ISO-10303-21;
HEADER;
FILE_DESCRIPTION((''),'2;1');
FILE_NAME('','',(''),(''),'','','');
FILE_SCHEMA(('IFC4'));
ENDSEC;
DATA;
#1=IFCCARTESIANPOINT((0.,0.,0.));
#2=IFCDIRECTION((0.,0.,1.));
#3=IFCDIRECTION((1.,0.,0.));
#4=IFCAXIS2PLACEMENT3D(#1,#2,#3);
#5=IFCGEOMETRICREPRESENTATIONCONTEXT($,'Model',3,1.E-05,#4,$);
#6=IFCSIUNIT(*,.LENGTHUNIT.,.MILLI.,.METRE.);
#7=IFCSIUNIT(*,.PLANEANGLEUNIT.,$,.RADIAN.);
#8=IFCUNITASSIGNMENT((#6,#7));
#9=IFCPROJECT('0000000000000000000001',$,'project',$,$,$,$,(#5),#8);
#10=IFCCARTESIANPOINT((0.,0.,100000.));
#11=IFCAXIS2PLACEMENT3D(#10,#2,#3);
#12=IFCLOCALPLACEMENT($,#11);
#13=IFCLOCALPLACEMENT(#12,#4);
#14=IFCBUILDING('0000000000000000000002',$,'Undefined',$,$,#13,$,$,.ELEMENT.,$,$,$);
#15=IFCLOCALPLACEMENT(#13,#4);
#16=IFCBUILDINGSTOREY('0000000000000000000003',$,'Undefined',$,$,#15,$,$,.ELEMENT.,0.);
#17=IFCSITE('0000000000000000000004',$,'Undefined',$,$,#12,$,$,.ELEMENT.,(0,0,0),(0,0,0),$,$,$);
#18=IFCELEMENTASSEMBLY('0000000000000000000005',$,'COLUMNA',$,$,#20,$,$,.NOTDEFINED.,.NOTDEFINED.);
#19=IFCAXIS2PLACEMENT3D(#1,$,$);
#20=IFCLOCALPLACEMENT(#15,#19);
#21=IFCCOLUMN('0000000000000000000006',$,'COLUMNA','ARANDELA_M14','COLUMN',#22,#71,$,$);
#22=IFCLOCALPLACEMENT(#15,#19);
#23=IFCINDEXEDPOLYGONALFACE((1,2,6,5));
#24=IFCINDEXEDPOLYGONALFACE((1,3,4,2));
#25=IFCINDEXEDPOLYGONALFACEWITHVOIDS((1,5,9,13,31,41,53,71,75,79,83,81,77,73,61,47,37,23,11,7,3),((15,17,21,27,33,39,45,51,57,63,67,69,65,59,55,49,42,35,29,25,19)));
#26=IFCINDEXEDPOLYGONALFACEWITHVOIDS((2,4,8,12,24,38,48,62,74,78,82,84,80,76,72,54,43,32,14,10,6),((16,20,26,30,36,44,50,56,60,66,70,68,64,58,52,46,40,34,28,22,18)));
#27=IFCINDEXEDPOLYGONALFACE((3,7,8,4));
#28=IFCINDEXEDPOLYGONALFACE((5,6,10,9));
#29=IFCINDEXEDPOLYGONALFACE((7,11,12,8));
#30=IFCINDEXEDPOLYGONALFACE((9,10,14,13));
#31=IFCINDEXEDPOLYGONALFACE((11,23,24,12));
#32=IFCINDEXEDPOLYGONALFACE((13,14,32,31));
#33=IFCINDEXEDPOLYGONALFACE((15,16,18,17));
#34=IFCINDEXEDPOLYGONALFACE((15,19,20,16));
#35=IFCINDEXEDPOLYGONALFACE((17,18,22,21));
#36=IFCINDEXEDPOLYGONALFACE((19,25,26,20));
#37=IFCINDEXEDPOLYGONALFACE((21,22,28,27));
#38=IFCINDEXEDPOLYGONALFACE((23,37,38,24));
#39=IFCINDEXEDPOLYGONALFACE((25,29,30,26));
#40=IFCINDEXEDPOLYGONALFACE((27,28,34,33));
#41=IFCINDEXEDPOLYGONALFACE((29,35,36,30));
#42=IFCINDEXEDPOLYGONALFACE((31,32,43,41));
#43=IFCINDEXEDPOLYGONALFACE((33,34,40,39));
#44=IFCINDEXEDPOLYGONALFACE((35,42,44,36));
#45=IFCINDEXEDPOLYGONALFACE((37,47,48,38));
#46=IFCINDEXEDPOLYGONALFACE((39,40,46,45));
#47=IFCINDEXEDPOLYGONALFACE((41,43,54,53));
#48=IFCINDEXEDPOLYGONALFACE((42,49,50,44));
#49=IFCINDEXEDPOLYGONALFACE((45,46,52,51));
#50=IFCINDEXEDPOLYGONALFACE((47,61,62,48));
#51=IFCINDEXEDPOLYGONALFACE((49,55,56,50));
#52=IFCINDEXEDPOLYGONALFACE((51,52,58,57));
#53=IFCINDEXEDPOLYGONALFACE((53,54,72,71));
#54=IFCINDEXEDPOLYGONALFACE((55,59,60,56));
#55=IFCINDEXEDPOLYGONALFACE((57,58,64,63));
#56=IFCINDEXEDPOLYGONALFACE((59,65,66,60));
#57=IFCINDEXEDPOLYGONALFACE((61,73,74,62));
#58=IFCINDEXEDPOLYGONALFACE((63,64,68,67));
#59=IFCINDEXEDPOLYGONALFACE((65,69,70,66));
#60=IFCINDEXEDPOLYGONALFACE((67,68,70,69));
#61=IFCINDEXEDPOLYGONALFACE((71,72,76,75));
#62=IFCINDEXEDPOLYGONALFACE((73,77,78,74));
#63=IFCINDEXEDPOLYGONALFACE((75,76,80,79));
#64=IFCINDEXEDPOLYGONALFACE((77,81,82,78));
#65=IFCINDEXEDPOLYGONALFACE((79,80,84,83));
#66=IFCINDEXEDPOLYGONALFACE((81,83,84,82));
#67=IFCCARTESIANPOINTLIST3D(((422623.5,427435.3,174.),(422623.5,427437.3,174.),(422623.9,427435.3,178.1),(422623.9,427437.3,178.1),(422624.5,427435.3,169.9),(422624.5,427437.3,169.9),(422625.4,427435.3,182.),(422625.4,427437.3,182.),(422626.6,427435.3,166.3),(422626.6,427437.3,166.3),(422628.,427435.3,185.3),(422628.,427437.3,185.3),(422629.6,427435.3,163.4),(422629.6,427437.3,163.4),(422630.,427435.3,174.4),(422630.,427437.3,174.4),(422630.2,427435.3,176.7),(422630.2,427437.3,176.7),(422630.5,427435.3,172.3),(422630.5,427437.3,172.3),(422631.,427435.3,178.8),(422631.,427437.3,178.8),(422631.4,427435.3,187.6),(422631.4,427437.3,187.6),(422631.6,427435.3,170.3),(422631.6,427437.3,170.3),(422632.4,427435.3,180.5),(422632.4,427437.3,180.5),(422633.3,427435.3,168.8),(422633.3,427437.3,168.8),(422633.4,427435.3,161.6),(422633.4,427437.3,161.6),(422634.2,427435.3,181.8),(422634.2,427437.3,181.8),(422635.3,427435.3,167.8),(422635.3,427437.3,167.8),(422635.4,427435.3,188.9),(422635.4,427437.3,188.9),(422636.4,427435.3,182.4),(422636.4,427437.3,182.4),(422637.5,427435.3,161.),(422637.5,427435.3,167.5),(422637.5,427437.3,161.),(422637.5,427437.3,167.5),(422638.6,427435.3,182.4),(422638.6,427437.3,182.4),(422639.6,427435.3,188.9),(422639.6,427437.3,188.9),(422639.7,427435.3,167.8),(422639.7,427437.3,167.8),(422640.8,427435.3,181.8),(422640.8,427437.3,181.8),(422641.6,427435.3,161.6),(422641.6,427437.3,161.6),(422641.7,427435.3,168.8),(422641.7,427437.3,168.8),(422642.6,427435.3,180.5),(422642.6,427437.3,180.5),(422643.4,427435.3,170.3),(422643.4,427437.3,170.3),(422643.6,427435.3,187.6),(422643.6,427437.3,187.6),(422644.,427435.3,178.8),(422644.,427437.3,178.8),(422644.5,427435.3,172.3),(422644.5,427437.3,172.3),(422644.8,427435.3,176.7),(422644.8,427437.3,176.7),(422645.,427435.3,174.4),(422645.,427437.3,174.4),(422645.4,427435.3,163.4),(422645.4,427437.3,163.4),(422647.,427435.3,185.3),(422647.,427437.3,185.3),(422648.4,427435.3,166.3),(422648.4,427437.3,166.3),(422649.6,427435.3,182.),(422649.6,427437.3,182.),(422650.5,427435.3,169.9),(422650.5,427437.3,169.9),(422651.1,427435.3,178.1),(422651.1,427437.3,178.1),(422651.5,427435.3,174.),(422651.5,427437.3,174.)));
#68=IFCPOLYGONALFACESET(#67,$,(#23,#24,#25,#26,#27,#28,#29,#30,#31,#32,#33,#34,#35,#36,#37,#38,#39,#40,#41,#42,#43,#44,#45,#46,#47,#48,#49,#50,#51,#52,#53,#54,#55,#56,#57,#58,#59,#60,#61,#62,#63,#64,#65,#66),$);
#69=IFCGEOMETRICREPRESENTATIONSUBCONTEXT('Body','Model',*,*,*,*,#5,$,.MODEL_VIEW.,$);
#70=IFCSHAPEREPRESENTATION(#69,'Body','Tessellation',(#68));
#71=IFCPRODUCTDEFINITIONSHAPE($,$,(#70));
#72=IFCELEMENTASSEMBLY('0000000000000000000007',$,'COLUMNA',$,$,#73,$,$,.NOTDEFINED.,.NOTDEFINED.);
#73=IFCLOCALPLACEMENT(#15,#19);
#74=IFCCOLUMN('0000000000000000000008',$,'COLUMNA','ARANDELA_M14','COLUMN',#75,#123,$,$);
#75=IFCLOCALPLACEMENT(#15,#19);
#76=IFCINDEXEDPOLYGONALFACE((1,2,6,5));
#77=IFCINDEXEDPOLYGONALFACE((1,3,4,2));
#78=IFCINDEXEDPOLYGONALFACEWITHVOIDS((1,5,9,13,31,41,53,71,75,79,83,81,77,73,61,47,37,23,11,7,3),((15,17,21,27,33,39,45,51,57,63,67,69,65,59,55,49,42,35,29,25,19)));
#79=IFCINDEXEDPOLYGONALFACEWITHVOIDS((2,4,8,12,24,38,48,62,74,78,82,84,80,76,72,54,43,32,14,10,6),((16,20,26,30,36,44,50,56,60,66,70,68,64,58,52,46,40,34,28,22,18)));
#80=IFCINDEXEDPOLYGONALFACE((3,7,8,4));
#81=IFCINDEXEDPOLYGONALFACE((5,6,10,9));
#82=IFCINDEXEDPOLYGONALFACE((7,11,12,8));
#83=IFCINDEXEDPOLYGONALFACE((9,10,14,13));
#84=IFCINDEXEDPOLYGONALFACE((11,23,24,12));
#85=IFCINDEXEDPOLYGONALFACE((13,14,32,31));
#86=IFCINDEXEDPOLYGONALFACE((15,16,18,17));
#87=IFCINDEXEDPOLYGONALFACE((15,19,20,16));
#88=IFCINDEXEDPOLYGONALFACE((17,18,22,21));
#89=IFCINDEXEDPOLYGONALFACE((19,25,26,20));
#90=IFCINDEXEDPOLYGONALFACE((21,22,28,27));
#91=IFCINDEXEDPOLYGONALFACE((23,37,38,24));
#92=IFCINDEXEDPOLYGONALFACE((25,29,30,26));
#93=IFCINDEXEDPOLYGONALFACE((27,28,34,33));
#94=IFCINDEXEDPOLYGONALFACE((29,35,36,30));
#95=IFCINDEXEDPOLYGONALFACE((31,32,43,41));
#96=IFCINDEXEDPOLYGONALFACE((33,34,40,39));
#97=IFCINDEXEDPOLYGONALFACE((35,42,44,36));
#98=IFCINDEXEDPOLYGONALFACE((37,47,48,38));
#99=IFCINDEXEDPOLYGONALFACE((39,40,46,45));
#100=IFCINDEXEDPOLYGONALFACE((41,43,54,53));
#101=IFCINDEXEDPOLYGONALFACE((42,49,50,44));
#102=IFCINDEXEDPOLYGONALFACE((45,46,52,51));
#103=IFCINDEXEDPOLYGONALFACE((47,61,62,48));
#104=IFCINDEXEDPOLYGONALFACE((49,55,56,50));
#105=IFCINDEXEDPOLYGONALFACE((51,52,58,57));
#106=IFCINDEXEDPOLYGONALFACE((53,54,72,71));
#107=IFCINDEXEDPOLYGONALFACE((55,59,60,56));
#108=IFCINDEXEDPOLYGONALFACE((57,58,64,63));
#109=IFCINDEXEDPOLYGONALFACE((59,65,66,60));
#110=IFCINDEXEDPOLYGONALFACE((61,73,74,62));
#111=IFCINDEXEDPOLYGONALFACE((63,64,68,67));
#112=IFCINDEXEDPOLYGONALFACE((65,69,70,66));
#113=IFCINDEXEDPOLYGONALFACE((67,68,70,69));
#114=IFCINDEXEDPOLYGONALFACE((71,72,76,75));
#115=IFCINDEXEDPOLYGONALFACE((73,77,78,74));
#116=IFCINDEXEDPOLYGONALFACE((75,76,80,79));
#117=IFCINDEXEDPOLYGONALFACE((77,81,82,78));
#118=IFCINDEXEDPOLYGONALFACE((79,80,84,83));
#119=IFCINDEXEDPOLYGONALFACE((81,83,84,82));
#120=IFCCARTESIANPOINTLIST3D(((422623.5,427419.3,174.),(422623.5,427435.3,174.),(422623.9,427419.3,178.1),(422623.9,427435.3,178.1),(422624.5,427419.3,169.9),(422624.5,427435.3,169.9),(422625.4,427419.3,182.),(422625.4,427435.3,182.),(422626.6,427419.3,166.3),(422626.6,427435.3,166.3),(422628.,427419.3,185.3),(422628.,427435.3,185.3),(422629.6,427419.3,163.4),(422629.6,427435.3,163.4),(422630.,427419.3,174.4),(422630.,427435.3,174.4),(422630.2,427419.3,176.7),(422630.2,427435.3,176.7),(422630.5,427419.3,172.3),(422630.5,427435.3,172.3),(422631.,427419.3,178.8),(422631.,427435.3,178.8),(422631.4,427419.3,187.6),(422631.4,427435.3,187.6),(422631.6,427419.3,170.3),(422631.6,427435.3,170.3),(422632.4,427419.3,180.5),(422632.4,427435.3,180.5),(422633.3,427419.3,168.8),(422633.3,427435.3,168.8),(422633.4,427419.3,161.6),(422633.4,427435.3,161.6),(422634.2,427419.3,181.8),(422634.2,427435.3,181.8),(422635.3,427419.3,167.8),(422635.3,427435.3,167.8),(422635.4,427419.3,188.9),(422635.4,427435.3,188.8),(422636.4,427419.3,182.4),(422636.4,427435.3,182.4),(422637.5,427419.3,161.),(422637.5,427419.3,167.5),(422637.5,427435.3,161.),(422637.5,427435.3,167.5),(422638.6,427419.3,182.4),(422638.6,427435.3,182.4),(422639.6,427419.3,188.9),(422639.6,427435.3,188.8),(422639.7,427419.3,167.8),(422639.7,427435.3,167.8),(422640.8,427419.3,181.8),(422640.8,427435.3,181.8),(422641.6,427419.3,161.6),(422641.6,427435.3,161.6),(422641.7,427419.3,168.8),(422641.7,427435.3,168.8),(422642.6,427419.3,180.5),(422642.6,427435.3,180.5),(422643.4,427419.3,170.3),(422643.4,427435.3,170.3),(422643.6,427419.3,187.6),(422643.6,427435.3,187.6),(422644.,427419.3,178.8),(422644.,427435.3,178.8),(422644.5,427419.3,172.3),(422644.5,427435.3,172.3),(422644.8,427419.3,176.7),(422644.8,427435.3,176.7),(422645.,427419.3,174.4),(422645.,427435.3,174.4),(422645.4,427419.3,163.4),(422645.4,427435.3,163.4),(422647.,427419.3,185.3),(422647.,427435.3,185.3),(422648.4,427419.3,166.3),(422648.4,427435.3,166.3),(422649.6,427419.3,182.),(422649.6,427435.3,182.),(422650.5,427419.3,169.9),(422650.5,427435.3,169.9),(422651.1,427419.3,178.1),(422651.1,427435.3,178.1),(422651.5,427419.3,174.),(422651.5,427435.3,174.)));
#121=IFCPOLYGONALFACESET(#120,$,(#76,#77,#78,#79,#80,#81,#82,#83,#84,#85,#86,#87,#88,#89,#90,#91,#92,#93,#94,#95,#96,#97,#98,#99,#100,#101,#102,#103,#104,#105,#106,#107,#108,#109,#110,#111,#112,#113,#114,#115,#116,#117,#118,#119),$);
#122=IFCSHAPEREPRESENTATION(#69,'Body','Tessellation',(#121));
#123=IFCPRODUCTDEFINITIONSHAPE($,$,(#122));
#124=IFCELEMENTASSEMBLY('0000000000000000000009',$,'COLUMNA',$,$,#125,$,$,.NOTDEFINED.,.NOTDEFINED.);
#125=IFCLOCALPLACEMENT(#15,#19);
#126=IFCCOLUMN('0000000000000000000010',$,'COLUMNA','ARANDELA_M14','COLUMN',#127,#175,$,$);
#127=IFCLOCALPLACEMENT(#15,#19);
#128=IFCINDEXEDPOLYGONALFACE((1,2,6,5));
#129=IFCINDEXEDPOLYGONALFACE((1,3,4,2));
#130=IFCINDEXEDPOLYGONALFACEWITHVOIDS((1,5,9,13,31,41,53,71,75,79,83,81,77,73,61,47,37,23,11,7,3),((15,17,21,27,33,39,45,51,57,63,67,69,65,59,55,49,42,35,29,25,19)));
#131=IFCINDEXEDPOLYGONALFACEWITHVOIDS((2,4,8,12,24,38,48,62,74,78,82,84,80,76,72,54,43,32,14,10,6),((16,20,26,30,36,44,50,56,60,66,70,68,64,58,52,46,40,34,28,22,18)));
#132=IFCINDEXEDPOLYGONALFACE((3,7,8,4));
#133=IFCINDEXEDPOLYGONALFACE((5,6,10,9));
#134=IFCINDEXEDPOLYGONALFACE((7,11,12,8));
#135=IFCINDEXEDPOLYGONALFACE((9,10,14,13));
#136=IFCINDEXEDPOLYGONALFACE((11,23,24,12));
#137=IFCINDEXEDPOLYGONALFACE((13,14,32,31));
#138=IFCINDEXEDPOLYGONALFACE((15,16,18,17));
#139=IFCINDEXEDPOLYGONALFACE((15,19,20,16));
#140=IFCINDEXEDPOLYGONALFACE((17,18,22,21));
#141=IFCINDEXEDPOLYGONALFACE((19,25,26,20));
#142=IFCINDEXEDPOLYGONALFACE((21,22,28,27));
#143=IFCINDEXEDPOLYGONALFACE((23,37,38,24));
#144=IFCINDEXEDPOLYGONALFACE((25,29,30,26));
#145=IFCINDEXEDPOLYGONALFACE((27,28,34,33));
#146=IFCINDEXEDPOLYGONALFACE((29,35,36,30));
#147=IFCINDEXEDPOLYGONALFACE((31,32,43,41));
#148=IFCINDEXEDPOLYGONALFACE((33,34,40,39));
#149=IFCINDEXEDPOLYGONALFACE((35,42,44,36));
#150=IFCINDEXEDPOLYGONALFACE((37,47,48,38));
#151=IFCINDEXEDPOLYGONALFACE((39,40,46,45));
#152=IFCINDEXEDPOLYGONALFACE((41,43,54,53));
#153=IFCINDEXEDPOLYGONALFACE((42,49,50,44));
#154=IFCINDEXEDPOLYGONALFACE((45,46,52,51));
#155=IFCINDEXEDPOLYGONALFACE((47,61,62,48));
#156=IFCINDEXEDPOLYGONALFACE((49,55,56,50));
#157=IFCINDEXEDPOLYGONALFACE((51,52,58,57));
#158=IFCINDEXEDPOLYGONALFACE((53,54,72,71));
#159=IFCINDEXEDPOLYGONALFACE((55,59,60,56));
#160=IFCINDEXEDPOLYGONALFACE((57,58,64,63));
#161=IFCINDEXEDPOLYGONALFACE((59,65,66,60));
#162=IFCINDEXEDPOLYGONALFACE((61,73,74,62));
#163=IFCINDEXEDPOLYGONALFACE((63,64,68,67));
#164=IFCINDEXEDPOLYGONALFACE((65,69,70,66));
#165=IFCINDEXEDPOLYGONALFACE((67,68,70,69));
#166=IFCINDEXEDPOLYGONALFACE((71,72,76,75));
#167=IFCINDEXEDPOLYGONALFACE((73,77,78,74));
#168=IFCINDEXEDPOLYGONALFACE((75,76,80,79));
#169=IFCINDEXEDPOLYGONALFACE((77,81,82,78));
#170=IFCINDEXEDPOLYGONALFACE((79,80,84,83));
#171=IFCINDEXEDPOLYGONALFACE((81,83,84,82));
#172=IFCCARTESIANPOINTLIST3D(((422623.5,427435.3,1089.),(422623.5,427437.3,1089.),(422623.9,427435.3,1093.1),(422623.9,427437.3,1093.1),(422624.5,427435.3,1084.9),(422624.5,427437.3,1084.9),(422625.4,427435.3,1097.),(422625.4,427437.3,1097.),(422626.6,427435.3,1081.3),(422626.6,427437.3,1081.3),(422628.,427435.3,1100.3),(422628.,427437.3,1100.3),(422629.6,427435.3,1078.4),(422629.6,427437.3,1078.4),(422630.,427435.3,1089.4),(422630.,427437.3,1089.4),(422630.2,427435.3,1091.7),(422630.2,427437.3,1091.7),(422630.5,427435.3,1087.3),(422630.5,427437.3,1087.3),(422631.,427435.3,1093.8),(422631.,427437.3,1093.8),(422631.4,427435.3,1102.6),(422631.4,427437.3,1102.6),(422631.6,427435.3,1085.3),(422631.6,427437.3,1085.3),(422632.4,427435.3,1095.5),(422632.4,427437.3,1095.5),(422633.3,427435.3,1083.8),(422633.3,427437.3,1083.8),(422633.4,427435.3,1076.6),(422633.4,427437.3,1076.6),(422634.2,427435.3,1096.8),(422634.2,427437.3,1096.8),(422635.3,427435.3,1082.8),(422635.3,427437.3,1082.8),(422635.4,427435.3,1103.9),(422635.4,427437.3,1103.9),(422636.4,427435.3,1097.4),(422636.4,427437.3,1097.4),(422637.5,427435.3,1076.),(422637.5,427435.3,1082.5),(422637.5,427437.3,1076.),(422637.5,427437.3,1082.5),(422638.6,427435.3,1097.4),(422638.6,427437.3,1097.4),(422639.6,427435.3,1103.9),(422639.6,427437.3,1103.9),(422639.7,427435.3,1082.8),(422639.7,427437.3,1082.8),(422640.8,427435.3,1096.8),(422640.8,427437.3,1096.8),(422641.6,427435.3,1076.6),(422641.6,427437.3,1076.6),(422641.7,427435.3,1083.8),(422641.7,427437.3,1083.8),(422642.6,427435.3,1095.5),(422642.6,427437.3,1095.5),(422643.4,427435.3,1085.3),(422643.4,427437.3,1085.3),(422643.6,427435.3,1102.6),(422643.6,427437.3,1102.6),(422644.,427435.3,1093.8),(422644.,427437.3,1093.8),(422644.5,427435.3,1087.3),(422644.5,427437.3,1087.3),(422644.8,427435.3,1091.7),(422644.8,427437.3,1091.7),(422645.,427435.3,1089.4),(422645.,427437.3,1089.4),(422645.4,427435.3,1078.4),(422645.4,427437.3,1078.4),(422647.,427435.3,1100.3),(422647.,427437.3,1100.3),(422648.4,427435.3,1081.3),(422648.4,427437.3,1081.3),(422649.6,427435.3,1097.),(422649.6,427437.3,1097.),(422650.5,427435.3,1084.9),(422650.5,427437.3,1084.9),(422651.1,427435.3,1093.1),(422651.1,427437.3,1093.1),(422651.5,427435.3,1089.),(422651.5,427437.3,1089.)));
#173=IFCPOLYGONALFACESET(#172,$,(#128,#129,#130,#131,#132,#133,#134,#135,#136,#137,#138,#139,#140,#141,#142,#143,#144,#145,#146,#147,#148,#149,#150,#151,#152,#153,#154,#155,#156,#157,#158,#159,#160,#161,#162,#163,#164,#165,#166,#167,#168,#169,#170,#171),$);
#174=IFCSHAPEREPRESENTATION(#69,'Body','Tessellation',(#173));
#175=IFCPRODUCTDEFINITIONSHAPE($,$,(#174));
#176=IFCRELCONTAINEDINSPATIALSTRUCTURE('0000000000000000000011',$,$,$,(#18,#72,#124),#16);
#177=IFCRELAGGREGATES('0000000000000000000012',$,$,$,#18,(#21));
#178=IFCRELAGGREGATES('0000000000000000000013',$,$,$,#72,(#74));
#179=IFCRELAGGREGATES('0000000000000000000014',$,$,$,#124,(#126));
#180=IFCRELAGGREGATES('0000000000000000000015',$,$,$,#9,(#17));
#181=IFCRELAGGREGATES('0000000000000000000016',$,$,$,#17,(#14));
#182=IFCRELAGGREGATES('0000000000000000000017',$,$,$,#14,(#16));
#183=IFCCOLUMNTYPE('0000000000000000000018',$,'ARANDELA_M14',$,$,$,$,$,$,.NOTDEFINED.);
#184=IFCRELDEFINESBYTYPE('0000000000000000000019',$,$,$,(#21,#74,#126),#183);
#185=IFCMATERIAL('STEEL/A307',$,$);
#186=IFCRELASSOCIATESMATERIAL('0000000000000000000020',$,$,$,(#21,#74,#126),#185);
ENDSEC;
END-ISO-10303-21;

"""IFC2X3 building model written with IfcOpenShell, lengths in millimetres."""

from ifc_helpers import new_model, si_unit, frame, origin_with_axes, origin_2d_with_axis, place, context, subcontext, project, spatial, hollow_circle, extrude, material, type_object, element, aggregate, save


model = new_model("IFC2X3")

# Units and contexts
model_context = context("Model", 3, precision=1e-05, world=origin_with_axes())
body_context = subcontext(model_context, "Body", "Model", "MODEL_VIEW")
ifc_project = project(units=[si_unit("LENGTHUNIT", "METRE", prefix="MILLI"), si_unit("PLANEANGLEUNIT", "RADIAN")], contexts=[model_context])

# Site, building, storey
site_placement = place(None, frame((0.0, 0.0, 100000.0), z_axis=(0.0, 0.0, 1.0), x_axis=(1.0, 0.0, 0.0)))
site = spatial("IfcSite", under=ifc_project, at=site_placement, Name="Undefined", CompositionType="ELEMENT", RefLatitude=(0, 0, 0), RefLongitude=(0, 0, 0))
building_placement = place(site_placement, origin_with_axes())
building = spatial("IfcBuilding", under=site, at=building_placement, Name="Undefined", CompositionType="ELEMENT")
storey_placement = place(building_placement, origin_with_axes())
storey = spatial("IfcBuildingStorey", under=building, at=storey_placement, Name="Undefined", CompositionType="ELEMENT", Elevation=0.0)

# Element assemblies, columns
ifc_material = material(Name="STEEL/A307")
column_type_1 = type_object("IfcColumnType", Name="ARANDELA_M14", PredefinedType="NOTDEFINED")
assembly_1_placement = place(storey_placement, origin_with_axes())
assembly_1 = element("IfcElementAssembly", 1, at=assembly_1_placement, inside=storey, Name="COLUMNA", AssemblyPlace="NOTDEFINED", PredefinedType="NOTDEFINED")
column_1_placement = place(assembly_1_placement, frame((422637.5, 427437.3, 175.0), z_axis=(0.0, -1.0, 0.000285), x_axis=(-1.0, 0.0, 0.0)))
column_1 = element("IfcColumn", 2, at=column_1_placement, type_object=column_type_1, material=ifc_material, Name="COLUMNA", Description="ARANDELA_M14", ObjectType="COLUMN", context=body_context, shape_type="SweptSolid", body=[
    extrude(hollow_circle(Radius=14.0, WallThickness=6.5, at=origin_2d_with_axis()), frame((0.0, 0.0, 2.0), z_axis=(0.0, 0.0, -1.0), x_axis=(0.0, 1.0, 0.0)), (0.0, 0.0, 1.0), 2.0),
])
aggregate(assembly_1, [column_1])
assembly_2_placement = place(storey_placement, origin_with_axes())
assembly_2 = element("IfcElementAssembly", 3, at=assembly_2_placement, inside=storey, Name="COLUMNA", AssemblyPlace="NOTDEFINED", PredefinedType="NOTDEFINED")
column_2_placement = place(assembly_2_placement, frame((422637.5, 427435.3, 175.0), z_axis=(0.0, -1.0, 0.000285), x_axis=(-1.0, 0.0, 0.0)))
column_2 = element("IfcColumn", 4, at=column_2_placement, type_object=column_type_1, material=ifc_material, Name="COLUMNA", Description="ARANDELA_M14", ObjectType="COLUMN", context=body_context, shape_type="SweptSolid", body=[
    extrude(hollow_circle(Radius=14.0, WallThickness=6.5, at=origin_2d_with_axis()), frame((0.0, 0.0, 16.0), z_axis=(0.0, 0.0, -1.0), x_axis=(0.0, 1.0, 0.0)), (0.0, 0.0, 1.0), 16.0),
])
aggregate(assembly_2, [column_2])
assembly_3_placement = place(storey_placement, origin_with_axes())
assembly_3 = element("IfcElementAssembly", 5, at=assembly_3_placement, inside=storey, Name="COLUMNA", AssemblyPlace="NOTDEFINED", PredefinedType="NOTDEFINED")
column_3_placement = place(assembly_3_placement, frame((422637.5, 427437.3, 1090.0), z_axis=(0.0, -1.0, 0.000285), x_axis=(-1.0, 0.0, 0.0)))
column_3 = element("IfcColumn", 6, at=column_3_placement, type_object=column_type_1, material=ifc_material, Name="COLUMNA", Description="ARANDELA_M14", ObjectType="COLUMN", context=body_context, shape_type="SweptSolid", body=[
    extrude(hollow_circle(Radius=14.0, WallThickness=6.5, at=origin_2d_with_axis()), frame((0.0, 0.0, 2.0), z_axis=(0.0, 0.0, -1.0), x_axis=(0.0, 1.0, 0.0)), (0.0, 0.0, 1.0), 2.0),
])
aggregate(assembly_3, [column_3])

save(model, "model.ifc")
